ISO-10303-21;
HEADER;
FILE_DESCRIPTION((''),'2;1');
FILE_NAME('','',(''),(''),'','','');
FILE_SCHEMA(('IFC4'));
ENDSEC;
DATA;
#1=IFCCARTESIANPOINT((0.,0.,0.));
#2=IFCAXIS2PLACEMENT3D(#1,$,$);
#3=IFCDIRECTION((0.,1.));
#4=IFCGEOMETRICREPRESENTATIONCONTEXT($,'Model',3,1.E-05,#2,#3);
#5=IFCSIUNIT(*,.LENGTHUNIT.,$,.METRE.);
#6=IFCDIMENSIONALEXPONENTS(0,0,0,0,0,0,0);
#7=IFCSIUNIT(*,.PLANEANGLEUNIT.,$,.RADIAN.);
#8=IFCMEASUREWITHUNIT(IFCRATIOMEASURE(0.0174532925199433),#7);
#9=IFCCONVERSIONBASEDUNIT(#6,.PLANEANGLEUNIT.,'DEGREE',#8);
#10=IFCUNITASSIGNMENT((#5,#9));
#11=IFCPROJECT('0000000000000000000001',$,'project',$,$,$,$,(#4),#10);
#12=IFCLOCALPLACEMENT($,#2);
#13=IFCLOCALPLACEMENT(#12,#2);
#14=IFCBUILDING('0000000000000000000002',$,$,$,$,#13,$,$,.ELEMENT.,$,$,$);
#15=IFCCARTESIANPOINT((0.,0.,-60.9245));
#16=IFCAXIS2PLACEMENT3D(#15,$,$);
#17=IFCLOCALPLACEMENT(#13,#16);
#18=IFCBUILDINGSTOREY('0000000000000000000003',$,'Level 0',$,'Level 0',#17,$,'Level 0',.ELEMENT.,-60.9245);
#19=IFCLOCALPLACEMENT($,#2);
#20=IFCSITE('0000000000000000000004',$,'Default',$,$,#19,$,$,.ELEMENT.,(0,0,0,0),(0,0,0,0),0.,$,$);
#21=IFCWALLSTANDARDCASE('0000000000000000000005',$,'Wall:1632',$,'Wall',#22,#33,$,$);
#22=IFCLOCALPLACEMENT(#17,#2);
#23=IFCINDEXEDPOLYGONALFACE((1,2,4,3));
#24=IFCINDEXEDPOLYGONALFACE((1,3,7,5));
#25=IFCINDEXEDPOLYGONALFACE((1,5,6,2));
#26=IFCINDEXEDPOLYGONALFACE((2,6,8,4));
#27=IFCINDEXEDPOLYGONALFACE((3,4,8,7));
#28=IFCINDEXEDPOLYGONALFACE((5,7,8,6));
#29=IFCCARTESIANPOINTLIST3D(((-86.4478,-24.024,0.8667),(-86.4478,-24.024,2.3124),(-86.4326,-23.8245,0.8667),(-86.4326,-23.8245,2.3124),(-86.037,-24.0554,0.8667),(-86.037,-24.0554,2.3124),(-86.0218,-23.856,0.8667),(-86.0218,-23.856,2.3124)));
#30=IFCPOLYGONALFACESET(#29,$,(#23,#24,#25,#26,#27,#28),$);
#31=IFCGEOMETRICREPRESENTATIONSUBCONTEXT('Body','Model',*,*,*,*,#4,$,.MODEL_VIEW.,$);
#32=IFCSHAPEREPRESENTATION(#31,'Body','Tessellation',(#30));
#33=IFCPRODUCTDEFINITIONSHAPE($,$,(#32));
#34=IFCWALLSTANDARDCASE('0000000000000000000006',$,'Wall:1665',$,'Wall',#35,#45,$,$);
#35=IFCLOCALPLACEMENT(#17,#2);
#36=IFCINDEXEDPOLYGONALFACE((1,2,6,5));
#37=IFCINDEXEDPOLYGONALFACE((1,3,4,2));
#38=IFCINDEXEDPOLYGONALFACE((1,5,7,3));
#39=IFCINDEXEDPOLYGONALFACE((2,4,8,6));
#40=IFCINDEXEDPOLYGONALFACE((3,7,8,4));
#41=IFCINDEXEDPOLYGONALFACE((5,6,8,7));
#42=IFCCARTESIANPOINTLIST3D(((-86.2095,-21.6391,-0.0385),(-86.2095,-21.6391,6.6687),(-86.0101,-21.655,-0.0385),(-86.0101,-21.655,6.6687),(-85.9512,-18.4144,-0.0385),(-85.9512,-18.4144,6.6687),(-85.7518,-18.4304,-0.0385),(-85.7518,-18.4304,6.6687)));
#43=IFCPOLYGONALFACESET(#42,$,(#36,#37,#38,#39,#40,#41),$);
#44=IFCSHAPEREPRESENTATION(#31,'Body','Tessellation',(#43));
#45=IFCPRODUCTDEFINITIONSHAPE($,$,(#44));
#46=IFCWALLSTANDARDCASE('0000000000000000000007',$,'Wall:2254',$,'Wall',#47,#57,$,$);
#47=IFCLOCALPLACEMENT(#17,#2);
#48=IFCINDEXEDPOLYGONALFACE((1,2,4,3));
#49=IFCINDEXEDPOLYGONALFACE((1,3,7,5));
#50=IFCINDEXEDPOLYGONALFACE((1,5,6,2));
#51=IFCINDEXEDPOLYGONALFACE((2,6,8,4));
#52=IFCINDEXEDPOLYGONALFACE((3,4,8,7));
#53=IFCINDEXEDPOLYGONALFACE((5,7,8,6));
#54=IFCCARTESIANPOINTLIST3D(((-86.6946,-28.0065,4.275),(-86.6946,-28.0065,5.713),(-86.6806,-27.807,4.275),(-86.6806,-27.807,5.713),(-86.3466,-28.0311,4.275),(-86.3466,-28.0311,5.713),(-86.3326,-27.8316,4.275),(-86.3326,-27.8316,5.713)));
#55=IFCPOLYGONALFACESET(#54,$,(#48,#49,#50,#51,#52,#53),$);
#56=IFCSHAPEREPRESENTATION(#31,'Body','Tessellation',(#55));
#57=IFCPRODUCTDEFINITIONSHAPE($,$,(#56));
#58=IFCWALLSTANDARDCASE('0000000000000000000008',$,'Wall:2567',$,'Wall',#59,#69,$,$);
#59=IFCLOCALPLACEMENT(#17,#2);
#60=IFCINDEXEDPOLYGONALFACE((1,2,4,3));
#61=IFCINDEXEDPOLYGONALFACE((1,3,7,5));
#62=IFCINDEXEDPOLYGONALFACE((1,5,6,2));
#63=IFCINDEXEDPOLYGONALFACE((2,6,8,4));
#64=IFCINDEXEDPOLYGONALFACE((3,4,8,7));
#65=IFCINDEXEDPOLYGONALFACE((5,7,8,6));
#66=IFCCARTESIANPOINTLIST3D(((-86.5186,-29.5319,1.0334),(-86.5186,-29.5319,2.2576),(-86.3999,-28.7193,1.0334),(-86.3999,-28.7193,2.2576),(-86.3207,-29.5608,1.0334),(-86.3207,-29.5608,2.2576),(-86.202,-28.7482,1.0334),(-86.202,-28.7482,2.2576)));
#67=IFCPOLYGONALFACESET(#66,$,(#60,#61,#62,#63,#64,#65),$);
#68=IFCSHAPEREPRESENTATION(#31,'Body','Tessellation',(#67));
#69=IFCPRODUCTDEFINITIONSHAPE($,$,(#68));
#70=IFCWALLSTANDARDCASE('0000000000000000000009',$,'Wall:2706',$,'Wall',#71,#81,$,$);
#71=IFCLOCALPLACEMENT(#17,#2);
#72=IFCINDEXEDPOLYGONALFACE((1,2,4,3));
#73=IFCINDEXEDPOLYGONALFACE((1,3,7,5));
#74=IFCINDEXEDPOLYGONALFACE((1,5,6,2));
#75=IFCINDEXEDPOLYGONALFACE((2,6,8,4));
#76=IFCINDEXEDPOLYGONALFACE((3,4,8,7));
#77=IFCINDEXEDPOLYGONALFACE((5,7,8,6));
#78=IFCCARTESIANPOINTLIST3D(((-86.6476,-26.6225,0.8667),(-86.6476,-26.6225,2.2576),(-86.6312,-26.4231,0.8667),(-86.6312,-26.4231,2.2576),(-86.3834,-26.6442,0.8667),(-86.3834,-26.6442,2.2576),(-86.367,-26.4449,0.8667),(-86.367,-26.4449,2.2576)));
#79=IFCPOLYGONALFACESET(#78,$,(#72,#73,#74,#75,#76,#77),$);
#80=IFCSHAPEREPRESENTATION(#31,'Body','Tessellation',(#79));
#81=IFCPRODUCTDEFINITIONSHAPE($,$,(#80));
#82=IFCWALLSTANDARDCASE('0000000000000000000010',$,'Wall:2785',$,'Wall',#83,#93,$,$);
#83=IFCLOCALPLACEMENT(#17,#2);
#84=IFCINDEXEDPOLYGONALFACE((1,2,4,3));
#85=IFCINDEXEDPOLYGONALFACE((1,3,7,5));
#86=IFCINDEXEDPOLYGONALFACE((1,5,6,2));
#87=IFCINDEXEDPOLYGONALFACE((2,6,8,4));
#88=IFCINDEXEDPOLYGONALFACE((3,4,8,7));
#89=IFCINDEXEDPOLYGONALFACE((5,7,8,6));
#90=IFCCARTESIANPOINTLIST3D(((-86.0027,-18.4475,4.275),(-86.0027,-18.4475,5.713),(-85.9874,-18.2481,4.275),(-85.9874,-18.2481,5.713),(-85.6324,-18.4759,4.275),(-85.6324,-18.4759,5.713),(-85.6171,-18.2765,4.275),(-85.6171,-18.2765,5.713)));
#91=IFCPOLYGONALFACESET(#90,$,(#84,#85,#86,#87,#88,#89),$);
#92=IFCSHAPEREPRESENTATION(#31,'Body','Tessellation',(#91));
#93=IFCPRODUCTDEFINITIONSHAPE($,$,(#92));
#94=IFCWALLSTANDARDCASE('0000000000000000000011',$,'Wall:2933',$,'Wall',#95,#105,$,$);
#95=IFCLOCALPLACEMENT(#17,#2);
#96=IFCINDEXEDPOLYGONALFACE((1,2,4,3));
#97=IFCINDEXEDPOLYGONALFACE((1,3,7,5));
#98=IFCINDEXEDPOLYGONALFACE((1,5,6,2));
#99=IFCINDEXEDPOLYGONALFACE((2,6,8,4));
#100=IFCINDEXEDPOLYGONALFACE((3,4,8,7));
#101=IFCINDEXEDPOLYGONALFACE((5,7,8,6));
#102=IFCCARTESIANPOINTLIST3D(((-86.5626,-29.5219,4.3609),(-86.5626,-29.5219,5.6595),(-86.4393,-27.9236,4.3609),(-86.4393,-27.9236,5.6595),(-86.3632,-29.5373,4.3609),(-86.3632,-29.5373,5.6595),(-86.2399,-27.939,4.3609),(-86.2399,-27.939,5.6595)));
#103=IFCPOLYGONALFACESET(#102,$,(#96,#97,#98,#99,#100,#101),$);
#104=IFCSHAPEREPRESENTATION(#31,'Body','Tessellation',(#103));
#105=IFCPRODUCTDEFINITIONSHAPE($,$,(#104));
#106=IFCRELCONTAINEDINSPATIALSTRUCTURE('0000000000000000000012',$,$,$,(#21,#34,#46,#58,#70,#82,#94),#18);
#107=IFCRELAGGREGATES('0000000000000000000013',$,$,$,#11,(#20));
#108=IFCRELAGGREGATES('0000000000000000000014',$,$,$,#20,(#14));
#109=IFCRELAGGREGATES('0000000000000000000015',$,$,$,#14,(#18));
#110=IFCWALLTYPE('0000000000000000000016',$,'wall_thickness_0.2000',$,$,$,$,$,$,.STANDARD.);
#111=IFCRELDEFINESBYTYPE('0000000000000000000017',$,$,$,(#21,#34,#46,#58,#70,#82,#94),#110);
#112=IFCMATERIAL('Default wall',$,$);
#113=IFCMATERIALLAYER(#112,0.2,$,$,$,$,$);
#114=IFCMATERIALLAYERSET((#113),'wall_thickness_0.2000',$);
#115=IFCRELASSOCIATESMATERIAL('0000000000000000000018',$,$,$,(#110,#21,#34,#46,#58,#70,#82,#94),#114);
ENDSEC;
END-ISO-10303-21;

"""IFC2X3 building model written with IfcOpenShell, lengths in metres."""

from ifc_helpers import new_model, entity, si_unit, converted_unit, direction, frame, origin, place, context, subcontext, project, spatial, polyline, outline, extrude, material, layer, layer_set, layer_usage, type_object, element, save


model = new_model("IFC2X3")

# Units and contexts
model_context = context("Model", 3, precision=1e-05, world=origin(), true_north=direction((0.0, 1.0)))
body_context = subcontext(model_context, "Body", "Model", "MODEL_VIEW")
ifc_project = project(units=[si_unit("LENGTHUNIT", "METRE"), converted_unit("PLANEANGLEUNIT", "DEGREE", entity("IfcRatioMeasure", 0.0174532925199433), si_unit("PLANEANGLEUNIT", "RADIAN"), dimensions=[0, 0, 0, 0, 0, 0, 0])], contexts=[model_context])

# Site, building, storey
site_placement = place(None, origin())
site = spatial("IfcSite", under=ifc_project, at=site_placement, Name="Default", CompositionType="ELEMENT", RefLatitude=(0, 0, 0, 0), RefLongitude=(0, 0, 0, 0), RefElevation=0.0)
placement_1 = place(None, origin())
building_placement = place(placement_1, origin())
building = spatial("IfcBuilding", under=site, at=building_placement, CompositionType="ELEMENT")
storey_placement = place(building_placement, frame((0.0, 0.0, -60.9245)))
storey = spatial("IfcBuildingStorey", under=building, at=storey_placement, Name="Level 0", ObjectType="Level 0", LongName="Level 0", CompositionType="ELEMENT", Elevation=-60.9245)

# Walls
ifc_material = material(Name="Default wall")
ifc_layer = layer(ifc_material, 0.2)
ifc_layer_set = layer_set([ifc_layer], Name="wall_thickness_0.2000")
ifc_layer_usage = layer_usage(ifc_layer_set, "AXIS2", "POSITIVE", -0.1)
wall_type = type_object("IfcWallType", Name="wall_thickness_0.2000", PredefinedType="STANDARD", material=ifc_layer_set)
placement_2 = place(building_placement, frame((0.0, 0.0, -60.0578)))
wall_1_placement = place(placement_2, frame((-86.4402, -23.9243, 0.0), z_axis=(0.0, 0.0, 1.0), x_axis=(0.997088, -0.076263, 0.0)))
element("IfcWallStandardCase", 1, at=wall_1_placement, inside=storey, type_object=wall_type, material=ifc_layer_usage, Name="Wall:1632", ObjectType="Wall", context=body_context, shape_type="SweptSolid", body=[
    extrude(outline(polyline([(0.412, -0.1), (0.412, 0.1), (0.0, 0.1), (0.0, -0.1), (0.412, -0.1)])), origin(), (0.0, 0.0, 1.0), 1.4457),
])
placement_3 = place(building_placement, frame((0.0, 0.0, -60.963)))
wall_2_placement = place(placement_3, frame((-86.1098, -21.647, 0.0), z_axis=(0.0, 0.0, 1.0), x_axis=(0.079855, 0.996806, 0.0)))
element("IfcWallStandardCase", 2, at=wall_2_placement, inside=storey, type_object=wall_type, material=ifc_layer_usage, Name="Wall:1665", ObjectType="Wall", context=body_context, shape_type="SweptSolid", body=[
    extrude(outline(polyline([(3.235, -0.1), (3.235, 0.1), (0.0, 0.1), (0.0, -0.1), (3.235, -0.1)])), origin(), (0.0, 0.0, 1.0), 6.7072),
])
placement_4 = place(building_placement, frame((0.0, 0.0, -56.6495)))
wall_3_placement = place(placement_4, frame((-86.3396, -27.9313, 0.0), z_axis=(0.0, 0.0, 1.0), x_axis=(-0.997518, 0.070405, 0.0)))
element("IfcWallStandardCase", 3, at=wall_3_placement, inside=storey, type_object=wall_type, material=ifc_layer_usage, Name="Wall:2254", ObjectType="Wall", context=body_context, shape_type="SweptSolid", body=[
    extrude(outline(polyline([(0.3488, -0.1), (0.3488, 0.1), (0.0, 0.1), (0.0, -0.1), (0.3488, -0.1)])), origin(), (0.0, 0.0, 1.0), 1.438),
])
placement_5 = place(building_placement, frame((0.0, 0.0, -59.8911)))
wall_4_placement = place(placement_5, frame((-86.3009, -28.7338, 0.0), z_axis=(0.0, 0.0, 1.0), x_axis=(-0.144539, -0.989499, 0.0)))
element("IfcWallStandardCase", 4, at=wall_4_placement, inside=storey, type_object=wall_type, material=ifc_layer_usage, Name="Wall:2567", ObjectType="Wall", context=body_context, shape_type="SweptSolid", body=[
    extrude(outline(polyline([(0.8212, -0.1), (0.8212, 0.1), (0.0, 0.1), (0.0, -0.1), (0.8212, -0.1)])), origin(), (0.0, 0.0, 1.0), 1.2243),
])
placement_6 = place(building_placement, frame((0.0, 0.0, -60.0578)))
wall_5_placement = place(placement_6, frame((-86.3752, -26.5445, 0.0), z_axis=(0.0, 0.0, 1.0), x_axis=(-0.996634, 0.081985, 0.0)))
element("IfcWallStandardCase", 5, at=wall_5_placement, inside=storey, type_object=wall_type, material=ifc_layer_usage, Name="Wall:2706", ObjectType="Wall", context=body_context, shape_type="SweptSolid", body=[
    extrude(outline(polyline([(0.265, -0.1), (0.265, 0.1), (0.0, 0.1), (0.0, -0.1), (0.265, -0.1)])), origin(), (0.0, 0.0, 1.0), 1.3909),
])
placement_7 = place(building_placement, frame((0.0, 0.0, -56.6495)))
wall_6_placement = place(placement_7, frame((-85.6247, -18.3762, 0.0), z_axis=(0.0, 0.0, 1.0), x_axis=(-0.997068, 0.076518, 0.0)))
element("IfcWallStandardCase", 6, at=wall_6_placement, inside=storey, type_object=wall_type, material=ifc_layer_usage, Name="Wall:2785", ObjectType="Wall", context=body_context, shape_type="SweptSolid", body=[
    extrude(outline(polyline([(0.3715, -0.1), (0.3715, 0.1), (0.0, 0.1), (0.0, -0.1), (0.3715, -0.1)])), origin(), (0.0, 0.0, 1.0), 1.438),
])
placement_8 = place(building_placement, frame((0.0, 0.0, -56.5636)))
wall_7_placement = place(placement_8, frame((-86.3396, -27.9313, 0.0), z_axis=(0.0, 0.0, 1.0), x_axis=(-0.076917, -0.997037, 0.0)))
element("IfcWallStandardCase", 7, at=wall_7_placement, inside=storey, type_object=wall_type, material=ifc_layer_usage, Name="Wall:2933", ObjectType="Wall", context=body_context, shape_type="SweptSolid", body=[
    extrude(outline(polyline([(1.603, -0.1), (1.603, 0.1), (0.0, 0.1), (0.0, -0.1), (1.603, -0.1)])), origin(), (0.0, 0.0, 1.0), 1.2985),
])

save(model, "model.ifc")
